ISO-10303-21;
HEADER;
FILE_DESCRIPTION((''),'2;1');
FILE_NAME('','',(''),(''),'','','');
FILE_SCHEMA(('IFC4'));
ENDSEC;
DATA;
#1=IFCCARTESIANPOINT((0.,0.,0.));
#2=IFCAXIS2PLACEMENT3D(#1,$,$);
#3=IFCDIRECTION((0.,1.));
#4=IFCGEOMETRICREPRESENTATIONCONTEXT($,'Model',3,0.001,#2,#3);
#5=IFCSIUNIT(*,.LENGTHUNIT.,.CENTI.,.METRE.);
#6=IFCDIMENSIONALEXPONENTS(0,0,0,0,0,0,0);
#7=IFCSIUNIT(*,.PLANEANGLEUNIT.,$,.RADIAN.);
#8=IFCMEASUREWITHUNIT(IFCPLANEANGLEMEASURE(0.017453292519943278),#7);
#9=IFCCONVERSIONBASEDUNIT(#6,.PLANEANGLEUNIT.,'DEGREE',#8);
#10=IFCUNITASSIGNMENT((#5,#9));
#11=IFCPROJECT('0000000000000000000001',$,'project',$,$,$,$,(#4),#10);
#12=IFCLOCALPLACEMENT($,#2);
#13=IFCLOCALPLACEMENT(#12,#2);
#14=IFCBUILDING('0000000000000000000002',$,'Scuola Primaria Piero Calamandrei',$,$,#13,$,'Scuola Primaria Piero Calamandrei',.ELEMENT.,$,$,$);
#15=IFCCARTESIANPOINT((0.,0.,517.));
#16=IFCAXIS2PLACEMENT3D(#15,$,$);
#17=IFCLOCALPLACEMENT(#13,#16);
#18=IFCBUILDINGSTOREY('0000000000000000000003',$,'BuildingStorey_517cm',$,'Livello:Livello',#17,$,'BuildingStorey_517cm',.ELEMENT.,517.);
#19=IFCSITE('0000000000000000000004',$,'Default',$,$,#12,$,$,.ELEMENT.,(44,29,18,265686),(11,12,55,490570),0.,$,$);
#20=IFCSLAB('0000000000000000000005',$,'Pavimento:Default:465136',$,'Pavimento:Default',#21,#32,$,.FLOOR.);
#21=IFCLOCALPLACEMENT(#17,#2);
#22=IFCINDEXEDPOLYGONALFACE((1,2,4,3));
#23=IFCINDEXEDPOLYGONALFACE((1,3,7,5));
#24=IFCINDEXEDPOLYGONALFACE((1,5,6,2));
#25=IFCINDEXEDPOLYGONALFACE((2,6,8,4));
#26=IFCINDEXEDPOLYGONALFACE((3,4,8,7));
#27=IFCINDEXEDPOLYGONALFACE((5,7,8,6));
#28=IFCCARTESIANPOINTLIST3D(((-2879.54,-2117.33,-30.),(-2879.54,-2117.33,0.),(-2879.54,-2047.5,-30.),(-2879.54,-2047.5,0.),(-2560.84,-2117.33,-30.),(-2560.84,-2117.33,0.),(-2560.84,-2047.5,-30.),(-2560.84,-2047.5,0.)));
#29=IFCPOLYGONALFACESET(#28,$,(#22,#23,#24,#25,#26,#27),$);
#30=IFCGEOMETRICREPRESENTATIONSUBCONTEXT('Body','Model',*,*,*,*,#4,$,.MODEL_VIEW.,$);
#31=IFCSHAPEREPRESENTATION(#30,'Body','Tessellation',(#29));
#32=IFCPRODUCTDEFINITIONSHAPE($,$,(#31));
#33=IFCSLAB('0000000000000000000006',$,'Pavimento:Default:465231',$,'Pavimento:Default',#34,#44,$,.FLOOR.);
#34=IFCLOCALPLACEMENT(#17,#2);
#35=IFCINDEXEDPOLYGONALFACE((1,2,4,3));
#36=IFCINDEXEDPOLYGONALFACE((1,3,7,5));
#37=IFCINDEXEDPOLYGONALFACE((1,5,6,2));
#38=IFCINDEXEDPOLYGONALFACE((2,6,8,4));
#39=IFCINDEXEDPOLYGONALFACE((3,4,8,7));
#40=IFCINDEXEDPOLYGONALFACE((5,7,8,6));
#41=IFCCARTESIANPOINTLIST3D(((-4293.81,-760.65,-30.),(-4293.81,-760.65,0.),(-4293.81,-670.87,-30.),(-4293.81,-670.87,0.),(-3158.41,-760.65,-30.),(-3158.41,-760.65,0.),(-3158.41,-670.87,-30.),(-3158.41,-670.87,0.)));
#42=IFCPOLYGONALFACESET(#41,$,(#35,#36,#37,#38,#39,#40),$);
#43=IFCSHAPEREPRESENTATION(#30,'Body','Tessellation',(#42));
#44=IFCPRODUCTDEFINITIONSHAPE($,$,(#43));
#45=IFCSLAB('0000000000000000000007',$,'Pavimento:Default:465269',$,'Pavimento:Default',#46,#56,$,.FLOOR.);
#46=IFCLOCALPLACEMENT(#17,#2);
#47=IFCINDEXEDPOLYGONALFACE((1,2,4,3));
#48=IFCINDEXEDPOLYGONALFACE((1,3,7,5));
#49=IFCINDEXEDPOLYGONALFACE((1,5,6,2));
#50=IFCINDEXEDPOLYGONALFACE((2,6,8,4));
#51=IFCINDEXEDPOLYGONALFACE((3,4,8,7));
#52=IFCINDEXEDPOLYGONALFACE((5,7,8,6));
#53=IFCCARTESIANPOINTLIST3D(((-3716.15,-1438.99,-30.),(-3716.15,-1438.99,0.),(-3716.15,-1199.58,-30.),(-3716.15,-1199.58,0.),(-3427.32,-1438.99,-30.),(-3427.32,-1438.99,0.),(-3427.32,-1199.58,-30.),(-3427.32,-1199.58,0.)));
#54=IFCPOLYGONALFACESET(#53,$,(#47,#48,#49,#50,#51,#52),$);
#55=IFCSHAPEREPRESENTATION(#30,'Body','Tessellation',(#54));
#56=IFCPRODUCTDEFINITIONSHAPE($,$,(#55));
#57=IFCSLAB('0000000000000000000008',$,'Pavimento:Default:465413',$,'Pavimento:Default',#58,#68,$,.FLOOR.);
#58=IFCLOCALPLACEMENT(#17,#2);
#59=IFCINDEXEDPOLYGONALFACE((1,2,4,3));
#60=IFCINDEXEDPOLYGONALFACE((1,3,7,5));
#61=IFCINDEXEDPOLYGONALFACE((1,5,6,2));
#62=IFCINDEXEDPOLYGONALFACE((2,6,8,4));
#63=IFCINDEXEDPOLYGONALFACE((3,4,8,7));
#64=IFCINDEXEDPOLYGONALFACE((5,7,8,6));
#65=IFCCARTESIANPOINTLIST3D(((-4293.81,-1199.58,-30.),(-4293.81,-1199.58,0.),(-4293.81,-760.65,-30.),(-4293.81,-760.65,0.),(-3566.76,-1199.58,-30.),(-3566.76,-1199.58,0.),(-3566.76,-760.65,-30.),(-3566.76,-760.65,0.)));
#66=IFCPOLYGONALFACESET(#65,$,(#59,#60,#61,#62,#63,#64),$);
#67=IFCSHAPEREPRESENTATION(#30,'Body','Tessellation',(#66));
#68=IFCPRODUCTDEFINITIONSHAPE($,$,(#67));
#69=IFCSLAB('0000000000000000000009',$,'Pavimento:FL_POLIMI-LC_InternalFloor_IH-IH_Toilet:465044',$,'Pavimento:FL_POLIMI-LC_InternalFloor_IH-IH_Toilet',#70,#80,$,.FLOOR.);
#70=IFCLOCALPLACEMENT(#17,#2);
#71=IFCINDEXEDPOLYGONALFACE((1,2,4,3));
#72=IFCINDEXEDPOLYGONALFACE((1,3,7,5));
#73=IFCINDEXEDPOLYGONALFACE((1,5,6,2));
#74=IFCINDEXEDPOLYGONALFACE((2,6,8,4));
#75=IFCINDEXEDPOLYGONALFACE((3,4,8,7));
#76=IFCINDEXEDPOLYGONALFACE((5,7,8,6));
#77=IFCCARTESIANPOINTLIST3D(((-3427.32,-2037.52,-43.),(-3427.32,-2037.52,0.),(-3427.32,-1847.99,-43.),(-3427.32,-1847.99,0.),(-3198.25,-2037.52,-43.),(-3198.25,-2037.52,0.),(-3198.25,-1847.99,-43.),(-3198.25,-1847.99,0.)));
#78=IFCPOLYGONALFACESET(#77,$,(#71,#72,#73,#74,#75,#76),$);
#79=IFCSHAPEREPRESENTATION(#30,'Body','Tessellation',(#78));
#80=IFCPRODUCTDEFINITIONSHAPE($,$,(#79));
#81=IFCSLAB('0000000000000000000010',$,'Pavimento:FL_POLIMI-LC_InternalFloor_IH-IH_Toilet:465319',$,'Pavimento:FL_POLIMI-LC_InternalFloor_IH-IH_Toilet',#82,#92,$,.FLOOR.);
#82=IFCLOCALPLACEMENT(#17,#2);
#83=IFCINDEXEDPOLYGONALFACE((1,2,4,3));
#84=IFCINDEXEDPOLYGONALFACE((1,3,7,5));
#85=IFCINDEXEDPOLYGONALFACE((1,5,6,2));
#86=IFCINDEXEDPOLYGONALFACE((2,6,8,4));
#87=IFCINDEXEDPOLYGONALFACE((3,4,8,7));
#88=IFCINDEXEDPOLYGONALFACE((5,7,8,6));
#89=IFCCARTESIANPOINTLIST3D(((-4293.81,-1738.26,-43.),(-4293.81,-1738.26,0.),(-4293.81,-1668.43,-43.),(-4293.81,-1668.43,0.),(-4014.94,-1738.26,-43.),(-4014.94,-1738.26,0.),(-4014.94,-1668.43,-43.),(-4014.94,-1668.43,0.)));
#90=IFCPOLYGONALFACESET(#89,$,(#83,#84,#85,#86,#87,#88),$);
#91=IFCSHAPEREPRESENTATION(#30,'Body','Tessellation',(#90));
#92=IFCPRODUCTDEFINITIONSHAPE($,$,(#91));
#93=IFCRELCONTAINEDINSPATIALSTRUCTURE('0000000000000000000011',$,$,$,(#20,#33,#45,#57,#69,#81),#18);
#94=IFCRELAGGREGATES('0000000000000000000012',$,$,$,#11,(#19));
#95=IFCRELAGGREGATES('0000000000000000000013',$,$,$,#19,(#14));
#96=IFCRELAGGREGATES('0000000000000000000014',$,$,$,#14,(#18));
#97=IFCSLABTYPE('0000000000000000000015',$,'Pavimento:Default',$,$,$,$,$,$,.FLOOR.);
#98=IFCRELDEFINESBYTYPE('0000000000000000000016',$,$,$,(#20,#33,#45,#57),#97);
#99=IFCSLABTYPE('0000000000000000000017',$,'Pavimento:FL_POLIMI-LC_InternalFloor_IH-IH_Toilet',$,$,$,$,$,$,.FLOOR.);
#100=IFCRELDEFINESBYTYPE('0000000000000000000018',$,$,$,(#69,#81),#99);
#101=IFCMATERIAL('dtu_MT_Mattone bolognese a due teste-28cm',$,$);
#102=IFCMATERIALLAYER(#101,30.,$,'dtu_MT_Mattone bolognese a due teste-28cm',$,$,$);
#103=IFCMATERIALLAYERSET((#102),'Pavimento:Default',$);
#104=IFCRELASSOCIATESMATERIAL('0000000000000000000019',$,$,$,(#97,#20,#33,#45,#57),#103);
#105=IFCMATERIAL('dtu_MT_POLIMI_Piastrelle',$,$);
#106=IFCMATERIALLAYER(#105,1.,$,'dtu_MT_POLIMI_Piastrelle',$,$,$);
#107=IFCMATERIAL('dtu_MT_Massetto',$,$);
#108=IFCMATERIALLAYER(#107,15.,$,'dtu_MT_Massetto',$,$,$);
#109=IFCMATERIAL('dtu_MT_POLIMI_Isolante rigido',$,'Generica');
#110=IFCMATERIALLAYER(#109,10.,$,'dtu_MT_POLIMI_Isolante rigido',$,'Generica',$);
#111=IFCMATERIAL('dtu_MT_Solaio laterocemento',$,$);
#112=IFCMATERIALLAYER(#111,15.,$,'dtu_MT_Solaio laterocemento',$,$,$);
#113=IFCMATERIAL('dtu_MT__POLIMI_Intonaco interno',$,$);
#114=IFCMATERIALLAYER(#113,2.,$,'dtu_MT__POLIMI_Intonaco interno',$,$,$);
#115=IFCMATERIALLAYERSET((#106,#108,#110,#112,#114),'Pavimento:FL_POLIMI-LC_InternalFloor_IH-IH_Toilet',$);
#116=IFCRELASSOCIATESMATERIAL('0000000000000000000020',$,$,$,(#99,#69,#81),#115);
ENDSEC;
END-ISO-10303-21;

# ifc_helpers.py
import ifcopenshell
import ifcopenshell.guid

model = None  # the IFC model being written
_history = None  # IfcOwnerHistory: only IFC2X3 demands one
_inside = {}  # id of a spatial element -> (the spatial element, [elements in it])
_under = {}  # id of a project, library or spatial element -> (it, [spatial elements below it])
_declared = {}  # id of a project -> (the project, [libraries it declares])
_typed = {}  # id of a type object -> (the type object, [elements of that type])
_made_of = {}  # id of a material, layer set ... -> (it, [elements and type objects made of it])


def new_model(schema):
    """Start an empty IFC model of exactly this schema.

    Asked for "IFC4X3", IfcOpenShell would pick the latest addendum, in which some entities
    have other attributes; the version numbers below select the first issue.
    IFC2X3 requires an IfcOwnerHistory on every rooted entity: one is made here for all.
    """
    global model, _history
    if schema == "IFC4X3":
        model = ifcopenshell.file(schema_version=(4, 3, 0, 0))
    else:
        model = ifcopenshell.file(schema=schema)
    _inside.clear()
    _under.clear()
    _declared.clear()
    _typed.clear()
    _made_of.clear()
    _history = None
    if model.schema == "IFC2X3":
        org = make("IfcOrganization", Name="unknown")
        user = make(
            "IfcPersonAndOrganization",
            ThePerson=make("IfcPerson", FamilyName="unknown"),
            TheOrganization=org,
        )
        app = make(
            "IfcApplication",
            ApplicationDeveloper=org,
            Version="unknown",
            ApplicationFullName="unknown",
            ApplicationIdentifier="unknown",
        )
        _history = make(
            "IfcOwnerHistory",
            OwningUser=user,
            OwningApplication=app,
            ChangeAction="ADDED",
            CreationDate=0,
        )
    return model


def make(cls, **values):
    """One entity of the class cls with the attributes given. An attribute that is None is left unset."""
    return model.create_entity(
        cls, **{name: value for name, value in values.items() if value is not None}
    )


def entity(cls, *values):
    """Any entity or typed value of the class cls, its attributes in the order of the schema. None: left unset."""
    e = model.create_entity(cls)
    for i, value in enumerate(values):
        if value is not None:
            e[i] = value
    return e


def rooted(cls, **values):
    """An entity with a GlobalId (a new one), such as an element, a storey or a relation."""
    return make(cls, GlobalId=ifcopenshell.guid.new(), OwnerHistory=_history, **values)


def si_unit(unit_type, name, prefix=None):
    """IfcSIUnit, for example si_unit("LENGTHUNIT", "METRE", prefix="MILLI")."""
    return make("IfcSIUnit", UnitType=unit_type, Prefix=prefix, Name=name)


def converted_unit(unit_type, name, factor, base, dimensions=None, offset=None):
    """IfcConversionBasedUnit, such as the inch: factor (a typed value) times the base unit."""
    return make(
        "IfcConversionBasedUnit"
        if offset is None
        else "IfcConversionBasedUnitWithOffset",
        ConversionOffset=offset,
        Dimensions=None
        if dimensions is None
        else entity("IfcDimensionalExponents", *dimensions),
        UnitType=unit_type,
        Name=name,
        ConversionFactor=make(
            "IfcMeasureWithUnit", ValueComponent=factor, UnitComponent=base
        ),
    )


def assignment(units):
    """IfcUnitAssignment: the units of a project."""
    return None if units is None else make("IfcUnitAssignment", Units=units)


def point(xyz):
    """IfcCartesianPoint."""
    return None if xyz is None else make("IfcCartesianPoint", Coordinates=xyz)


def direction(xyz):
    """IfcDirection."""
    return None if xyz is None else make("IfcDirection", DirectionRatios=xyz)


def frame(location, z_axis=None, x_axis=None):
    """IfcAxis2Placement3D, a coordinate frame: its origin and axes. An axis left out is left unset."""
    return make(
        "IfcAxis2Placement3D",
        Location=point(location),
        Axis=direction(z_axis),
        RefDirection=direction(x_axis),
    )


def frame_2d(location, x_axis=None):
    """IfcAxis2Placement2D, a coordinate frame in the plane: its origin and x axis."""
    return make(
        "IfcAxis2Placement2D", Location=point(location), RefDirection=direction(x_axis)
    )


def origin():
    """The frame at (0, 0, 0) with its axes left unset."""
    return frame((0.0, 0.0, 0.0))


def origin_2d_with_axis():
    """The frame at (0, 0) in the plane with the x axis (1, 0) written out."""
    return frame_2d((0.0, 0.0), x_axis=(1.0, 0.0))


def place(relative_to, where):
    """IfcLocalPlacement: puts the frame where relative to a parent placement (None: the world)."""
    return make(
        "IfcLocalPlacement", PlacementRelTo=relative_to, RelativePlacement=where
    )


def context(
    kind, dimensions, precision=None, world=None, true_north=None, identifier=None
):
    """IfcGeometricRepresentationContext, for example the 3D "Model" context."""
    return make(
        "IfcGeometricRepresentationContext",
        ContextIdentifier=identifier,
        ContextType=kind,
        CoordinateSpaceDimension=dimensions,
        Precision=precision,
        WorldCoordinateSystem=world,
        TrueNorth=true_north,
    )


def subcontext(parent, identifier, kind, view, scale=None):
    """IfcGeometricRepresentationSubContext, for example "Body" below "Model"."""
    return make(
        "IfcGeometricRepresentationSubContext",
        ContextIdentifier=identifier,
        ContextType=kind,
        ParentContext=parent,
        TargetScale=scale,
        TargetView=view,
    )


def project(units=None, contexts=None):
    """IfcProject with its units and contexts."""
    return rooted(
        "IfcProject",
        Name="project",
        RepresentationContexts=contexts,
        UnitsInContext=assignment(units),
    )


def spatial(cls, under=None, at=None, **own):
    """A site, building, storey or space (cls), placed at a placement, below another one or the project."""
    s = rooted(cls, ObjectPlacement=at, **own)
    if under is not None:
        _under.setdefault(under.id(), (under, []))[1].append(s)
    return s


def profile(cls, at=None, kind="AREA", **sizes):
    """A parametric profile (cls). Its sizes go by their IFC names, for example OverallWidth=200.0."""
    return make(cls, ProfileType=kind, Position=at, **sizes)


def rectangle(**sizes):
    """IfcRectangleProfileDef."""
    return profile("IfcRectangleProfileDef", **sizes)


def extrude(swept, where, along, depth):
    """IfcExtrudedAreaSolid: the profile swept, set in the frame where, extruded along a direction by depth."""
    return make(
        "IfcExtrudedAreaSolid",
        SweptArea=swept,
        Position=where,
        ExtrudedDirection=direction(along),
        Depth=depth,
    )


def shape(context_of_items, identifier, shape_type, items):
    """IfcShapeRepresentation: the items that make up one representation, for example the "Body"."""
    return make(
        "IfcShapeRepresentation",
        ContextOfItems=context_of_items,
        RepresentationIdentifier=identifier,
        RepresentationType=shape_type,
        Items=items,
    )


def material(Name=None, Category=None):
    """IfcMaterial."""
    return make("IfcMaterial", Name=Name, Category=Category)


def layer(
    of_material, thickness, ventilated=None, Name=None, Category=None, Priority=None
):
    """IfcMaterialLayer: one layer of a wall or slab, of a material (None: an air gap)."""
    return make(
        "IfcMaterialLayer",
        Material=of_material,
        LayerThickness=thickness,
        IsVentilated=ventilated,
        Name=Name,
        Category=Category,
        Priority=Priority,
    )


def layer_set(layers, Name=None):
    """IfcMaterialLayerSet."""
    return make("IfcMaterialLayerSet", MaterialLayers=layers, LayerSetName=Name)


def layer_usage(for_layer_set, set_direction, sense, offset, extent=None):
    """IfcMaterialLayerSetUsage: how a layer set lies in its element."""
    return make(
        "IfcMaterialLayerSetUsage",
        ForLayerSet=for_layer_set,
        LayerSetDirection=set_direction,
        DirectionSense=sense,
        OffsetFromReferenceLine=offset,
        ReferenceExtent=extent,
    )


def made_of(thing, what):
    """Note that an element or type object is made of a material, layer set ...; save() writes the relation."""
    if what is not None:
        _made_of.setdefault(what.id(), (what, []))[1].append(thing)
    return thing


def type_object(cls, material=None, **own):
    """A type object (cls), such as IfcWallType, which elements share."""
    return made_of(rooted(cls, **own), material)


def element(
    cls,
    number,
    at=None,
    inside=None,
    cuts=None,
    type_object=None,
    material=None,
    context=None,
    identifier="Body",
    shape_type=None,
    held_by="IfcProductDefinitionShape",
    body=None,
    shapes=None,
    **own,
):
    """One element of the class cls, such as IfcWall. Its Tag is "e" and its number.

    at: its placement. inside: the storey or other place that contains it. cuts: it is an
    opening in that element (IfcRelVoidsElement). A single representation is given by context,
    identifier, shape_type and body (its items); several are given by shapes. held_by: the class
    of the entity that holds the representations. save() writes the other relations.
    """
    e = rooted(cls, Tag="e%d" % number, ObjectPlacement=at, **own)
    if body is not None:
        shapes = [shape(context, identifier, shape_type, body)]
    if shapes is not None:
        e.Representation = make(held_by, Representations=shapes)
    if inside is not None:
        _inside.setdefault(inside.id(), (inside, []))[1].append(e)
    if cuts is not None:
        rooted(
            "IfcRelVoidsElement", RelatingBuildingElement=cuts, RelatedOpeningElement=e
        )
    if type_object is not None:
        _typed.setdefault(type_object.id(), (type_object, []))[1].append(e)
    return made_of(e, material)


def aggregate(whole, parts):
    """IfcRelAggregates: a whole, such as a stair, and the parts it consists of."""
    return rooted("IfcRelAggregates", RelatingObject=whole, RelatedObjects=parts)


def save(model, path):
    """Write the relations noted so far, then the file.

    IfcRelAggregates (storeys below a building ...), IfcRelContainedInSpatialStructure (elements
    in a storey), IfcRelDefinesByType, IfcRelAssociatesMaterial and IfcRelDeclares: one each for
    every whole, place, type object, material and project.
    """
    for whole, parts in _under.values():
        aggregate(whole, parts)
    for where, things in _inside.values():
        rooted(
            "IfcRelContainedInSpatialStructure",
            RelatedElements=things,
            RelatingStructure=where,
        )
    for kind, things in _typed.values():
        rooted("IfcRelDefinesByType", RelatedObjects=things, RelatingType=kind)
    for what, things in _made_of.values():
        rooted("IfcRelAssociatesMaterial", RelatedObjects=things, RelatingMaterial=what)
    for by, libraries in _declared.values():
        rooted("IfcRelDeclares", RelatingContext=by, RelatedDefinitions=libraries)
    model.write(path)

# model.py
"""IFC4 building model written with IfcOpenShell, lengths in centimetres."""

from ifc_helpers import new_model, entity, si_unit, converted_unit, direction, frame, frame_2d, origin, origin_2d_with_axis, place, context, subcontext, project, spatial, rectangle, extrude, material, layer, layer_set, layer_usage, type_object, element, save


model = new_model("IFC4")

# Units and contexts
model_context = context("Model", 3, precision=0.001, world=origin(), true_north=direction((0.0, 1.0)))
body_context = subcontext(model_context, "Body", "Model", "MODEL_VIEW")
ifc_project = project(units=[si_unit("LENGTHUNIT", "METRE", prefix="CENTI"), converted_unit("PLANEANGLEUNIT", "DEGREE", entity("IfcPlaneAngleMeasure", 0.017453292519943278), si_unit("PLANEANGLEUNIT", "RADIAN"), dimensions=[0, 0, 0, 0, 0, 0, 0])], contexts=[model_context])

# Site, building, storey
site_placement = place(None, origin())
site = spatial("IfcSite", under=ifc_project, at=site_placement, Name="Default", CompositionType="ELEMENT", RefLatitude=(44, 29, 18, 265686), RefLongitude=(11, 12, 55, 490570), RefElevation=0.0)
building_placement = place(site_placement, origin())
building = spatial("IfcBuilding", under=site, at=building_placement, Name="Scuola Primaria Piero Calamandrei", LongName="Scuola Primaria Piero Calamandrei", CompositionType="ELEMENT")
storey_placement = place(building_placement, frame((0.0, 0.0, 517.0)))
storey = spatial("IfcBuildingStorey", under=building, at=storey_placement, Name="BuildingStorey_517cm", ObjectType="Livello:Livello", LongName="BuildingStorey_517cm", CompositionType="ELEMENT", Elevation=517.0)

# Slabs
ifc_material_1 = material(Name="dtu_MT_Massetto")
ifc_material_2 = material(Name="dtu_MT_POLIMI_Isolante rigido", Category="Generica")
ifc_material_3 = material(Name="dtu_MT_Solaio laterocemento")
ifc_material_4 = material(Name="dtu_MT__POLIMI_Intonaco interno")
ifc_material_5 = material(Name="dtu_MT_Mattone bolognese a due teste-28cm")
ifc_layer_1 = layer(ifc_material_5, 30.0, Name="dtu_MT_Mattone bolognese a due teste-28cm")
ifc_layer_set_1 = layer_set([ifc_layer_1], Name="Pavimento:Default")
slab_type_1 = type_object("IfcSlabType", Name="Pavimento:Default", PredefinedType="FLOOR", material=ifc_layer_set_1)
ifc_layer_usage_1 = layer_usage(ifc_layer_set_1, "AXIS3", "POSITIVE", 0.0)
slab_1_placement = place(storey_placement, origin())
element("IfcSlab", 1, at=slab_1_placement, inside=storey, type_object=slab_type_1, material=ifc_layer_usage_1, Name="Pavimento:Default:465136", ObjectType="Pavimento:Default", PredefinedType="FLOOR", context=body_context, shape_type="SweptSolid", body=[
    extrude(rectangle(XDim=69.83, YDim=318.71, at=frame_2d((0.0, 0.0), x_axis=(1.0, 0.0))), frame((-2720.19, -2082.41, 0.0), z_axis=(0.0, 0.0, -1.0), x_axis=(0.0, 1.0, 0.0)), (0.0, 0.0, 1.0), 30.0),
])
ifc_layer_usage_2 = layer_usage(ifc_layer_set_1, "AXIS3", "POSITIVE", 0.0)
slab_2_placement = place(storey_placement, origin())
element("IfcSlab", 2, at=slab_2_placement, inside=storey, type_object=slab_type_1, material=ifc_layer_usage_2, Name="Pavimento:Default:465231", ObjectType="Pavimento:Default", PredefinedType="FLOOR", context=body_context, shape_type="SweptSolid", body=[
    extrude(rectangle(XDim=89.78, YDim=1135.4, at=frame_2d((0.0, 0.0), x_axis=(1.0, 0.0))), frame((-3726.11, -715.76, 0.0), z_axis=(0.0, 0.0, -1.0), x_axis=(0.0, 1.0, 0.0)), (0.0, 0.0, 1.0), 30.0),
])
ifc_layer_usage_3 = layer_usage(ifc_layer_set_1, "AXIS3", "POSITIVE", 0.0)
slab_3_placement = place(storey_placement, origin())
element("IfcSlab", 3, at=slab_3_placement, inside=storey, type_object=slab_type_1, material=ifc_layer_usage_3, Name="Pavimento:Default:465269", ObjectType="Pavimento:Default", PredefinedType="FLOOR", context=body_context, shape_type="SweptSolid", body=[
    extrude(rectangle(XDim=239.41, YDim=288.83, at=origin_2d_with_axis()), frame((-3571.74, -1319.28, 0.0), z_axis=(0.0, 0.0, -1.0), x_axis=(0.0, 1.0, 0.0)), (0.0, 0.0, 1.0), 30.0),
])
ifc_layer_usage_4 = layer_usage(ifc_layer_set_1, "AXIS3", "POSITIVE", 0.0)
slab_4_placement = place(storey_placement, origin())
element("IfcSlab", 4, at=slab_4_placement, inside=storey, type_object=slab_type_1, material=ifc_layer_usage_4, Name="Pavimento:Default:465413", ObjectType="Pavimento:Default", PredefinedType="FLOOR", context=body_context, shape_type="SweptSolid", body=[
    extrude(rectangle(XDim=438.92, YDim=727.05, at=frame_2d((0.0, 0.0), x_axis=(1.0, 0.0))), frame((-3930.28, -980.11, 0.0), z_axis=(0.0, 0.0, -1.0), x_axis=(0.0, 1.0, 0.0)), (0.0, 0.0, 1.0), 30.0),
])
ifc_material_6 = material(Name="dtu_MT_POLIMI_Piastrelle")
ifc_layer_2 = layer(ifc_material_6, 1.0, Name="dtu_MT_POLIMI_Piastrelle")
ifc_layer_3 = layer(ifc_material_1, 15.0, Name="dtu_MT_Massetto")
ifc_layer_4 = layer(ifc_material_2, 10.0, Name="dtu_MT_POLIMI_Isolante rigido", Category="Generica")
ifc_layer_5 = layer(ifc_material_3, 15.0, Name="dtu_MT_Solaio laterocemento")
ifc_layer_6 = layer(ifc_material_4, 2.0, Name="dtu_MT__POLIMI_Intonaco interno")
ifc_layer_set_2 = layer_set([ifc_layer_2, ifc_layer_3, ifc_layer_4, ifc_layer_5, ifc_layer_6], Name="Pavimento:FL_POLIMI-LC_InternalFloor_IH-IH_Toilet")
ifc_layer_usage_5 = layer_usage(ifc_layer_set_2, "AXIS3", "POSITIVE", 0.0)
slab_type_2 = type_object("IfcSlabType", Name="Pavimento:FL_POLIMI-LC_InternalFloor_IH-IH_Toilet", PredefinedType="FLOOR", material=ifc_layer_set_2)
slab_5_placement = place(storey_placement, origin())
element("IfcSlab", 5, at=slab_5_placement, inside=storey, type_object=slab_type_2, material=ifc_layer_usage_5, Name="Pavimento:FL_POLIMI-LC_InternalFloor_IH-IH_Toilet:465044", ObjectType="Pavimento:FL_POLIMI-LC_InternalFloor_IH-IH_Toilet", PredefinedType="FLOOR", context=body_context, shape_type="SweptSolid", body=[
    extrude(rectangle(XDim=189.54, YDim=229.07, at=frame_2d((0.0, 0.0), x_axis=(1.0, 0.0))), frame((-3312.79, -1942.75, 0.0), z_axis=(0.0, 0.0, -1.0), x_axis=(0.0, 1.0, 0.0)), (0.0, 0.0, 1.0), 43.0),
])
ifc_layer_usage_6 = layer_usage(ifc_layer_set_2, "AXIS3", "POSITIVE", 0.0)
slab_6_placement = place(storey_placement, origin())
element("IfcSlab", 6, at=slab_6_placement, inside=storey, type_object=slab_type_2, material=ifc_layer_usage_6, Name="Pavimento:FL_POLIMI-LC_InternalFloor_IH-IH_Toilet:465319", ObjectType="Pavimento:FL_POLIMI-LC_InternalFloor_IH-IH_Toilet", PredefinedType="FLOOR", context=body_context, shape_type="SweptSolid", body=[
    extrude(rectangle(XDim=69.83, YDim=278.87, at=frame_2d((0.0, 0.0), x_axis=(1.0, 0.0))), frame((-4154.37, -1703.34, 0.0), z_axis=(0.0, 0.0, -1.0), x_axis=(0.0, 1.0, 0.0)), (0.0, 0.0, 1.0), 43.0),
])

save(model, "model.ifc")
